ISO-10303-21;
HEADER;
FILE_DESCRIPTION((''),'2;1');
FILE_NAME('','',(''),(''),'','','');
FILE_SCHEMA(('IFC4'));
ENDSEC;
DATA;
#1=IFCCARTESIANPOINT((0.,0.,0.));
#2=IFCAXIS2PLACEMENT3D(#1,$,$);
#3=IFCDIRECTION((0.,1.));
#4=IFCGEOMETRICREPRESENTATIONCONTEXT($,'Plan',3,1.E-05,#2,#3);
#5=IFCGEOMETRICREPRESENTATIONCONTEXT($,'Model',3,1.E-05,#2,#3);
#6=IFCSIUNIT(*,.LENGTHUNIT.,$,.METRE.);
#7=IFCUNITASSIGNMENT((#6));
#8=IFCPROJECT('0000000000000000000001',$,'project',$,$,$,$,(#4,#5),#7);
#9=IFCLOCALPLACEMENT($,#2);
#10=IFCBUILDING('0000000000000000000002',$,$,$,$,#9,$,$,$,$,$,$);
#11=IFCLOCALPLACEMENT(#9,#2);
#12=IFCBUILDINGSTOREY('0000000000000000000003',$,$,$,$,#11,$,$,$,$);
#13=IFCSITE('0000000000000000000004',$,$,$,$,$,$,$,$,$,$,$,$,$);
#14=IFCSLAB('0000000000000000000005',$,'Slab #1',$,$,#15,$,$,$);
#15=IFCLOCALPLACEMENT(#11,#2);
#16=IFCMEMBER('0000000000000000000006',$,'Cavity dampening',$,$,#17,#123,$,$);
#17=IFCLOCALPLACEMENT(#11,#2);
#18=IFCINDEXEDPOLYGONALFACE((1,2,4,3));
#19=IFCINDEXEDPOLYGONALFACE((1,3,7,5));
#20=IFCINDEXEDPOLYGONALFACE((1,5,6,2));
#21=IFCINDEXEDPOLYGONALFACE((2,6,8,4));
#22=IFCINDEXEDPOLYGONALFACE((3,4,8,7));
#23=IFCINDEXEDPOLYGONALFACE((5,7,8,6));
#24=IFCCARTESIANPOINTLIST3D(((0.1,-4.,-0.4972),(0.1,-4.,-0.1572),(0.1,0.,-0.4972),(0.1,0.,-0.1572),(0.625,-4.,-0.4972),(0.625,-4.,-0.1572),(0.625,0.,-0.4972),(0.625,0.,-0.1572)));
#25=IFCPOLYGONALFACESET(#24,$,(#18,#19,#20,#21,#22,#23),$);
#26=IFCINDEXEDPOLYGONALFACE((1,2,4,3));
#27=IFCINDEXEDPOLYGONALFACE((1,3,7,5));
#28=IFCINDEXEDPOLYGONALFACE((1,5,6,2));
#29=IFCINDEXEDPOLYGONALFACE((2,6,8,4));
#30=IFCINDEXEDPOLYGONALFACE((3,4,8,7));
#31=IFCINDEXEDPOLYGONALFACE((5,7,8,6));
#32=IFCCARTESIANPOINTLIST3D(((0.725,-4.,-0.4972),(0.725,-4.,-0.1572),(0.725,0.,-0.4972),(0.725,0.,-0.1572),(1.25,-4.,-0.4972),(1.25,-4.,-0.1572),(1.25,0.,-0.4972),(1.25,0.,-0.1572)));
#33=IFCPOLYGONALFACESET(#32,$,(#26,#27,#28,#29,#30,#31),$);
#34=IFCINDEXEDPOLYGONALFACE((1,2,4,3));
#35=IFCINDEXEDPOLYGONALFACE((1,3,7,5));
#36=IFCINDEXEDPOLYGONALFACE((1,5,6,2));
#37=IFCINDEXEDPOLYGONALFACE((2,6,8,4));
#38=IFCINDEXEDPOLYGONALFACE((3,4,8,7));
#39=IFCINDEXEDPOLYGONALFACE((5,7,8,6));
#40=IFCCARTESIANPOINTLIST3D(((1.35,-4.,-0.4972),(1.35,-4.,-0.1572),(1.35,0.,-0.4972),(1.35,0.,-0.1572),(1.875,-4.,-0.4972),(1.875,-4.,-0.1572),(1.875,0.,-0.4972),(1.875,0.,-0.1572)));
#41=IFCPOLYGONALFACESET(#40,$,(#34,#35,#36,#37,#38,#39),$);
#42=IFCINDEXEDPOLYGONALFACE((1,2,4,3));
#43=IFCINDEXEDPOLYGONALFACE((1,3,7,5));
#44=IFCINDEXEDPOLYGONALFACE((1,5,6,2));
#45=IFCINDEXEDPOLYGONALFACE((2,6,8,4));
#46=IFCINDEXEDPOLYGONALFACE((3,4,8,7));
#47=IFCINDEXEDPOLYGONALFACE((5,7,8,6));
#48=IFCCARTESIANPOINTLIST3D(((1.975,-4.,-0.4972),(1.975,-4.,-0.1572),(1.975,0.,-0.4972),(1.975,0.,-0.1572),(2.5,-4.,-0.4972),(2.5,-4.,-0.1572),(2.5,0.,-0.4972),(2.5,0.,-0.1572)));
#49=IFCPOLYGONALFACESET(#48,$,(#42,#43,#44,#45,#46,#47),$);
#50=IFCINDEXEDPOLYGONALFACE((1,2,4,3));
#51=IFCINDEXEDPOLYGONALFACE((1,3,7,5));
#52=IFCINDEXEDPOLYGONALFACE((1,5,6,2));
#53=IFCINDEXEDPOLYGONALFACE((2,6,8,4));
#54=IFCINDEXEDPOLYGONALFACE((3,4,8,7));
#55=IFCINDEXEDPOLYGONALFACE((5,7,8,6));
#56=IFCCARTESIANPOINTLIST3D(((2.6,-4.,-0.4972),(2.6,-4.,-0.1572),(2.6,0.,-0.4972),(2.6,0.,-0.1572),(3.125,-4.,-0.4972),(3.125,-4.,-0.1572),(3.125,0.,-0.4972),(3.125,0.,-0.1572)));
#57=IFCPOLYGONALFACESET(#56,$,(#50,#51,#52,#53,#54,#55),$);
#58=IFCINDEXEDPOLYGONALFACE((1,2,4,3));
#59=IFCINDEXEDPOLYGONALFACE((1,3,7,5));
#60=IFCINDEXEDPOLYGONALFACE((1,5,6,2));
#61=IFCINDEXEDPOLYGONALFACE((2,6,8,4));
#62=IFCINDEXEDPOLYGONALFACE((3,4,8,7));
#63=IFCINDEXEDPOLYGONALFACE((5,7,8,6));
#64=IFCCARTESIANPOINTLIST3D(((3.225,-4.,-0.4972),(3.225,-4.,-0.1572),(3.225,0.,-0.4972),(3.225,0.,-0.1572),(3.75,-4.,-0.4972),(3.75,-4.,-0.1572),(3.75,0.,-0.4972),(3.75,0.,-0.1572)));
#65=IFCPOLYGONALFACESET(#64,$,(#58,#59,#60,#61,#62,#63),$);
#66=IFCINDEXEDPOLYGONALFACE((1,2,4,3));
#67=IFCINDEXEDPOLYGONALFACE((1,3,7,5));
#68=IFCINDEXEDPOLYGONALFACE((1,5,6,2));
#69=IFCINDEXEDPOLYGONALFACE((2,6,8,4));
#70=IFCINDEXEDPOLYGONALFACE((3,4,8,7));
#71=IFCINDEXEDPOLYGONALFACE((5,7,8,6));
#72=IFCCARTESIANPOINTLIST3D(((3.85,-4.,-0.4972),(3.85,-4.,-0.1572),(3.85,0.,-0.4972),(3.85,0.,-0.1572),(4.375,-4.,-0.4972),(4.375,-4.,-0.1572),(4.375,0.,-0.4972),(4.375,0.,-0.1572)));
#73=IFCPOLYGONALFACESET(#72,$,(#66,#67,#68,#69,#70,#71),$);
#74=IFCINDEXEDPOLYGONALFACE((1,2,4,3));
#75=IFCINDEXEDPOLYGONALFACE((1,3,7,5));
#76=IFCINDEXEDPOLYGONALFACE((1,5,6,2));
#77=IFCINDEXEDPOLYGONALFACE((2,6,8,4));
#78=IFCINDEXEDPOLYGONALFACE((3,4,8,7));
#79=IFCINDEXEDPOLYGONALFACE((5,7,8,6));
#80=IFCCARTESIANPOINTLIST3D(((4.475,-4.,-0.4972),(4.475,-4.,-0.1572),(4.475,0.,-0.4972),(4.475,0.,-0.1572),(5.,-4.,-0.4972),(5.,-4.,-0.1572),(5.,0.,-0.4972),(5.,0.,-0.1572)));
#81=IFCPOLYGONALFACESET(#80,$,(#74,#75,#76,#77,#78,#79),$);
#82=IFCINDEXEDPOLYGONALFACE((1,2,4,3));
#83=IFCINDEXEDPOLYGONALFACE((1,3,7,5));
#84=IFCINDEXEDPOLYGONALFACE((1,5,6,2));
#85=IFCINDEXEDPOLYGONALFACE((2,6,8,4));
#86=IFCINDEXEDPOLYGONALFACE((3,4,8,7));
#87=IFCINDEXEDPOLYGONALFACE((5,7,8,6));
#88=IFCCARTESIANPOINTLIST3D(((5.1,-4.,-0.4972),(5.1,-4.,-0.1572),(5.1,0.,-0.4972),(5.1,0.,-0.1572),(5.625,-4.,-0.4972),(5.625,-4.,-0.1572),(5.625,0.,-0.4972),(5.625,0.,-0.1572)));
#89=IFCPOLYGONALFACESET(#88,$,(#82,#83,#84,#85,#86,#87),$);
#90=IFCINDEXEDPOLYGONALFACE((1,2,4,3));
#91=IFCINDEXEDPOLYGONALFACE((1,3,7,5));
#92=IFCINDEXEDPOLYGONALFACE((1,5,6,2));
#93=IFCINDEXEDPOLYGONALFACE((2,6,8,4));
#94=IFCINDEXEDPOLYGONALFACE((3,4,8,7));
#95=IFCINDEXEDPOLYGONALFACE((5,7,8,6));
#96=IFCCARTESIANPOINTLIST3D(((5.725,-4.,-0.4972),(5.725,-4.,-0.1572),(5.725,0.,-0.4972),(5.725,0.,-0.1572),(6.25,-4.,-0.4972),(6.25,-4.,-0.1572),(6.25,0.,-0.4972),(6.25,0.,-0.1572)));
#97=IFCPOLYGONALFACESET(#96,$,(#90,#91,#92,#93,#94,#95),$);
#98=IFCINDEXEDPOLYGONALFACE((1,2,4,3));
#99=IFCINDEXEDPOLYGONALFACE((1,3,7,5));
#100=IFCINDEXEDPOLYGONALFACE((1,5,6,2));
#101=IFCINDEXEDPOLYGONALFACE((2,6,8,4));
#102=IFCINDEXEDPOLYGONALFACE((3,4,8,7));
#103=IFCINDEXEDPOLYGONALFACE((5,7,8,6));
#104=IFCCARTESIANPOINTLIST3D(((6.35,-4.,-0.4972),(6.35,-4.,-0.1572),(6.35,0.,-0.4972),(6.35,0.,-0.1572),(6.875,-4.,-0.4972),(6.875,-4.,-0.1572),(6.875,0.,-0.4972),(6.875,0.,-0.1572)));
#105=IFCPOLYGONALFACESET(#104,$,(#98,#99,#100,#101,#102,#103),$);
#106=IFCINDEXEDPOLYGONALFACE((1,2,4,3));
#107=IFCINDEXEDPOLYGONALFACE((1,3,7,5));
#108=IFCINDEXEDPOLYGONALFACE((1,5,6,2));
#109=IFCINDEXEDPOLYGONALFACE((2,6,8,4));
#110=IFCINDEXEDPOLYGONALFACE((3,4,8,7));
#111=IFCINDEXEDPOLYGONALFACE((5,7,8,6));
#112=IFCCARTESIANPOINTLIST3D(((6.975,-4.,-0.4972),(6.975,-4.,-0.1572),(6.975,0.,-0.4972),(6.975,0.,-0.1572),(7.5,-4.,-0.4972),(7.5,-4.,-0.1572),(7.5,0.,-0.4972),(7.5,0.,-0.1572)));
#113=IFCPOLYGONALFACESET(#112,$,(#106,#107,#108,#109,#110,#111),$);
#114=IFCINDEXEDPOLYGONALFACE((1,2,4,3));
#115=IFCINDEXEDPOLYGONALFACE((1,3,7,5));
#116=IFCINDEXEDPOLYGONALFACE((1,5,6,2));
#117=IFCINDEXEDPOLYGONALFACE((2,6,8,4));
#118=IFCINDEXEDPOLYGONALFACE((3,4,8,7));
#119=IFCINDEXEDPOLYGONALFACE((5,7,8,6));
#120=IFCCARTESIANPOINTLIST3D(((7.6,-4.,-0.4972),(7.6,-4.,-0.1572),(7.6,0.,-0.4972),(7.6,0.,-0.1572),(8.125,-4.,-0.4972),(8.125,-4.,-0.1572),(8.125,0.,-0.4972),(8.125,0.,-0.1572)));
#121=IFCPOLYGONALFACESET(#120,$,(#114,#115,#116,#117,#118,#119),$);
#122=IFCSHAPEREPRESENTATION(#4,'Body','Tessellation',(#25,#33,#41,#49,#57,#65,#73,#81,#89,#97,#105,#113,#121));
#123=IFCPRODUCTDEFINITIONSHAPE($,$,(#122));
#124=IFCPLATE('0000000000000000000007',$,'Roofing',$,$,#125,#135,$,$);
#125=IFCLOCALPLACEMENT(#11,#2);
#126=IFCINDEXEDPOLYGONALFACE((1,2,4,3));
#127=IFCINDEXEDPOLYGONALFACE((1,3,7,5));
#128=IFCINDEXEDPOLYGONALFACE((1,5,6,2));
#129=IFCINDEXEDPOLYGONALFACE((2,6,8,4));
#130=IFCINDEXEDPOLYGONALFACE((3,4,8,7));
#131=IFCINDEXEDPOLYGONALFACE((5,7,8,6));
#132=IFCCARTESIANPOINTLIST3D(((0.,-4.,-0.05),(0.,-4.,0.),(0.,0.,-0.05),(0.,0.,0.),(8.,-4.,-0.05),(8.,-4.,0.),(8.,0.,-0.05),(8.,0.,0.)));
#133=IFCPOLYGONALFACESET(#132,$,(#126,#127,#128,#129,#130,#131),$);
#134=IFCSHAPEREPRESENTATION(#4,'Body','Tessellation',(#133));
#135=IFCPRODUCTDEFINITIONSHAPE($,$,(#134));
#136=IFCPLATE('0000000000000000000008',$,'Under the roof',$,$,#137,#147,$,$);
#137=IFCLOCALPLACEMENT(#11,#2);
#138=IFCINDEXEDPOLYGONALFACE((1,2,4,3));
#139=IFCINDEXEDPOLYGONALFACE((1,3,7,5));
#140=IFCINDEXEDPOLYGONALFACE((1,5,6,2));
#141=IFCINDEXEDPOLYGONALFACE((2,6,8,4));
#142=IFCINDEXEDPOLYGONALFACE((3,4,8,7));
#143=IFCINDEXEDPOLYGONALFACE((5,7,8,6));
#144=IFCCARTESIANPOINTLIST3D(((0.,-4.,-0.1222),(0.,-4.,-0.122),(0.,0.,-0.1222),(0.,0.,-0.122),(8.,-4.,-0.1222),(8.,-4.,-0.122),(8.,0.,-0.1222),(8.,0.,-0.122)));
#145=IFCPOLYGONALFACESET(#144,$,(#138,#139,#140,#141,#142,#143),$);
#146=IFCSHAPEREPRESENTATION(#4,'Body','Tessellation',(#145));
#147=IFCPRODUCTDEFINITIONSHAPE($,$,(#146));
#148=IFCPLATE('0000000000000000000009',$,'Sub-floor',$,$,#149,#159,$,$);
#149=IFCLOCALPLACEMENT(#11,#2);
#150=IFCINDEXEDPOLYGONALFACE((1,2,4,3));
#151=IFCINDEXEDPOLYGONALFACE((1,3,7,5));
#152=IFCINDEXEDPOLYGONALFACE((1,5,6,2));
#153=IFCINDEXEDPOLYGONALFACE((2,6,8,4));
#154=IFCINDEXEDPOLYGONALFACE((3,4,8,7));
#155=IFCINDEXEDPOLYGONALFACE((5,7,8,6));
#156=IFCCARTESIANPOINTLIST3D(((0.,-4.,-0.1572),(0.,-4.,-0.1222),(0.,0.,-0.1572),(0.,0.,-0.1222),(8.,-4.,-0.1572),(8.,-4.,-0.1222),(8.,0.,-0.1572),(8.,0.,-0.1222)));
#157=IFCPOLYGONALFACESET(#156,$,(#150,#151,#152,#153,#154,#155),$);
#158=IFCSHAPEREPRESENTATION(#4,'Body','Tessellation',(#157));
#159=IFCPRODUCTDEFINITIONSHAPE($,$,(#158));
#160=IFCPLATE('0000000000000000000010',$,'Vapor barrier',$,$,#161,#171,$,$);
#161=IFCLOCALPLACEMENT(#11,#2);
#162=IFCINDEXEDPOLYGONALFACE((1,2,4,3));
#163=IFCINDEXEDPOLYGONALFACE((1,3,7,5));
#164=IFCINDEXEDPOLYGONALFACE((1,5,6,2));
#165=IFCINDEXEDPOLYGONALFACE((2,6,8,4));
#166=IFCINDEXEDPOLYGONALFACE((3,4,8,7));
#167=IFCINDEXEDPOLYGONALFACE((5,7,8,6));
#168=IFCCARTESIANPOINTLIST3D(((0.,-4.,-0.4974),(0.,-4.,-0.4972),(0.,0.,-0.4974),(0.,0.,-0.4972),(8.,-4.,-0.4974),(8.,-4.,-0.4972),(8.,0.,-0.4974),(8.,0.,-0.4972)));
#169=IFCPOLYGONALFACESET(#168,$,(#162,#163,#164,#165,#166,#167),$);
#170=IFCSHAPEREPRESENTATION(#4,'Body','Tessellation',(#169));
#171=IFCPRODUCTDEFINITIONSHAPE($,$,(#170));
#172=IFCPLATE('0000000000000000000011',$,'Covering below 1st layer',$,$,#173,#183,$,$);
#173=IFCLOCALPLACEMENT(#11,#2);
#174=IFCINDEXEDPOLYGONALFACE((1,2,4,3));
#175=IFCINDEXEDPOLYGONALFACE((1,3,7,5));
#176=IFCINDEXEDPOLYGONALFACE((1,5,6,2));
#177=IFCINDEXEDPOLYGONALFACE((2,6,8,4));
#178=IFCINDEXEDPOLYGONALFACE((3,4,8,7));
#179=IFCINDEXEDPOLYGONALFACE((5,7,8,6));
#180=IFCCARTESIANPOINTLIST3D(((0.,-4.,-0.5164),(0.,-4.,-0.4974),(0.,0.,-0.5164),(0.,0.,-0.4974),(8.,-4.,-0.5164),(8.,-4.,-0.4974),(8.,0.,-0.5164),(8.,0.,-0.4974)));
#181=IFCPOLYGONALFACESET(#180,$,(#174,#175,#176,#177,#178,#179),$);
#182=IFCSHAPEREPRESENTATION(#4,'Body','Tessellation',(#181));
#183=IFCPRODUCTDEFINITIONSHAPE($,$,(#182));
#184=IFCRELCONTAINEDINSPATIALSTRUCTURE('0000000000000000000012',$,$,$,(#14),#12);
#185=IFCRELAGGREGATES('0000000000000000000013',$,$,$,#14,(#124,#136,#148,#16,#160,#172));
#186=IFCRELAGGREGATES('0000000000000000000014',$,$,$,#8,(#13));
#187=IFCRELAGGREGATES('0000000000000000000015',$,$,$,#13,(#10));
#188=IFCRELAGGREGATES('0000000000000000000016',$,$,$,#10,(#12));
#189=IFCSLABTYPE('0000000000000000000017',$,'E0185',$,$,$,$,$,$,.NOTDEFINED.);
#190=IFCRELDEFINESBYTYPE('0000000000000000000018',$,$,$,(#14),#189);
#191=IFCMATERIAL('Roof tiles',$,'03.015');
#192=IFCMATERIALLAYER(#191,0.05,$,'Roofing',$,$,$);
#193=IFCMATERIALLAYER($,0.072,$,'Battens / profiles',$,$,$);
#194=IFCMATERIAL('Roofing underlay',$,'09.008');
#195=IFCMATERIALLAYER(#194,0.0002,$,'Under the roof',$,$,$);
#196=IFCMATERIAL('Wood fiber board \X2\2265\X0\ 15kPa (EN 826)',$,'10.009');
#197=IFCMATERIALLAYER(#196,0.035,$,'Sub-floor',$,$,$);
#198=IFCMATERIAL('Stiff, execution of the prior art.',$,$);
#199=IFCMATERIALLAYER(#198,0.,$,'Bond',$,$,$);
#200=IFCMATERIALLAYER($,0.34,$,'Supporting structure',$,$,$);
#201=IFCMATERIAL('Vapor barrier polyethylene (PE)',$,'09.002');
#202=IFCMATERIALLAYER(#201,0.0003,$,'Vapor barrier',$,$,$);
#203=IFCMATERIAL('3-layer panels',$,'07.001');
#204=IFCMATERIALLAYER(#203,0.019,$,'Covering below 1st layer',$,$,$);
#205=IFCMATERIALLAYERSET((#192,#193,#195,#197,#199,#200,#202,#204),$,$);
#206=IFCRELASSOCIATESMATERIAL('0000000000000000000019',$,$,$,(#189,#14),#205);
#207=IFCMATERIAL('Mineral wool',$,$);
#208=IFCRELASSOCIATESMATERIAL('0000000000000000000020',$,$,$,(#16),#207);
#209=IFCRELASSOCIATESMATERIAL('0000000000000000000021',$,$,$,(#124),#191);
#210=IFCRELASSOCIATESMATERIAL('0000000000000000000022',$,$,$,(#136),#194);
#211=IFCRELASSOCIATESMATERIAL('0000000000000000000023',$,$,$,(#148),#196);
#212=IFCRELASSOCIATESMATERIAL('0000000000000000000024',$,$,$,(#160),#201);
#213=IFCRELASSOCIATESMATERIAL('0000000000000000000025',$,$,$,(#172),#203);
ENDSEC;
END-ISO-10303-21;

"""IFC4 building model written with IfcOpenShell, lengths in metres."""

from ifc_helpers import new_model, si_unit, direction, frame, frame_2d, origin, origin_with_axes, place, context, project, spatial, rectangle, extrude, material, layer, layer_set, type_object, element, aggregate, save


model = new_model("IFC4")

# Units and contexts
plan_context = context("Plan", 3, precision=1e-05, world=origin(), true_north=direction((0.0, 1.0)))
model_context = context("Model", 3, precision=1e-05, world=origin(), true_north=direction((0.0, 1.0)))
ifc_project = project(units=[si_unit("LENGTHUNIT", "METRE")], contexts=[plan_context, model_context])

# Site, building, storey
site = spatial("IfcSite", under=ifc_project)
building_placement = place(None, origin())
building = spatial("IfcBuilding", under=site, at=building_placement)
storey_placement = place(building_placement, origin())
storey = spatial("IfcBuildingStorey", under=building, at=storey_placement)

# Slab, member, plates
ifc_material_1 = material(Name="Roof tiles", Category="03.015")
ifc_layer_1 = layer(ifc_material_1, 0.05, Name="Roofing")
ifc_layer_2 = layer(None, 0.072, Name="Battens / profiles")
ifc_material_2 = material(Name="Roofing underlay", Category="09.008")
ifc_layer_3 = layer(ifc_material_2, 0.0002, Name="Under the roof")
ifc_material_3 = material(Name="Wood fiber board ≥ 15kPa (EN 826)", Category="10.009")
ifc_layer_4 = layer(ifc_material_3, 0.035, Name="Sub-floor")
ifc_material_4 = material(Name="Stiff, execution of the prior art.")
ifc_layer_5 = layer(ifc_material_4, 0.0, Name="Bond")
ifc_layer_6 = layer(None, 0.34, Name="Supporting structure")
ifc_material_5 = material(Name="Vapor barrier polyethylene (PE)", Category="09.002")
ifc_layer_7 = layer(ifc_material_5, 0.0003, Name="Vapor barrier")
ifc_material_6 = material(Name="3-layer panels", Category="07.001")
ifc_layer_8 = layer(ifc_material_6, 0.019, Name="Covering below 1st layer")
ifc_layer_set = layer_set([ifc_layer_1, ifc_layer_2, ifc_layer_3, ifc_layer_4, ifc_layer_5, ifc_layer_6, ifc_layer_7, ifc_layer_8])
slab_type = type_object("IfcSlabType", Name="E0185", PredefinedType="NOTDEFINED", material=ifc_layer_set)
slab_placement = place(None, frame((0.0, 0.0, 0.0), z_axis=(0.0, 0.0, -1.0), x_axis=(1.0, 0.0, 0.0)))
slab = element("IfcSlab", 1, at=slab_placement, inside=storey, type_object=slab_type, material=ifc_layer_set, Name="Slab #1")
ifc_material_7 = material(Name="Mineral wool")
member_1_placement = place(slab_placement, origin())
member_1 = element("IfcMember", 2, at=member_1_placement, material=ifc_material_7, Name="Cavity dampening", context=plan_context, shape_type="SweptSolid", body=[
    extrude(rectangle(XDim=0.525, YDim=0.34, at=frame_2d((0.2625, 0.17), x_axis=(1.0, 0.0))), frame((0.1, 4.0, 0.1572), z_axis=(0.0, -1.0, 0.0), x_axis=(1.0, 0.0, 0.0)), (0.0, 0.0, 1.0), 4.0),
    extrude(rectangle(XDim=0.525, YDim=0.34, at=frame_2d((0.2625, 0.17), x_axis=(1.0, 0.0))), frame((0.725, 4.0, 0.1572), z_axis=(0.0, -1.0, 0.0), x_axis=(1.0, 0.0, 0.0)), (0.0, 0.0, 1.0), 4.0),
    extrude(rectangle(XDim=0.525, YDim=0.34, at=frame_2d((0.2625, 0.17), x_axis=(1.0, 0.0))), frame((1.35, 4.0, 0.1572), z_axis=(0.0, -1.0, 0.0), x_axis=(1.0, 0.0, 0.0)), (0.0, 0.0, 1.0), 4.0),
    extrude(rectangle(XDim=0.525, YDim=0.34, at=frame_2d((0.2625, 0.17), x_axis=(1.0, 0.0))), frame((1.975, 4.0, 0.1572), z_axis=(0.0, -1.0, 0.0), x_axis=(1.0, 0.0, 0.0)), (0.0, 0.0, 1.0), 4.0),
    extrude(rectangle(XDim=0.525, YDim=0.34, at=frame_2d((0.2625, 0.17), x_axis=(1.0, 0.0))), frame((2.6, 4.0, 0.1572), z_axis=(0.0, -1.0, 0.0), x_axis=(1.0, 0.0, 0.0)), (0.0, 0.0, 1.0), 4.0),
    extrude(rectangle(XDim=0.525, YDim=0.34, at=frame_2d((0.2625, 0.17), x_axis=(1.0, 0.0))), frame((3.225, 4.0, 0.1572), z_axis=(0.0, -1.0, 0.0), x_axis=(1.0, 0.0, 0.0)), (0.0, 0.0, 1.0), 4.0),
    extrude(rectangle(XDim=0.525, YDim=0.34, at=frame_2d((0.2625, 0.17), x_axis=(1.0, 0.0))), frame((3.85, 4.0, 0.1572), z_axis=(0.0, -1.0, 0.0), x_axis=(1.0, 0.0, 0.0)), (0.0, 0.0, 1.0), 4.0),
    extrude(rectangle(XDim=0.525, YDim=0.34, at=frame_2d((0.2625, 0.17), x_axis=(1.0, 0.0))), frame((4.475, 4.0, 0.1572), z_axis=(0.0, -1.0, 0.0), x_axis=(1.0, 0.0, 0.0)), (0.0, 0.0, 1.0), 4.0),
    extrude(rectangle(XDim=0.525, YDim=0.34, at=frame_2d((0.2625, 0.17), x_axis=(1.0, 0.0))), frame((5.1, 4.0, 0.1572), z_axis=(0.0, -1.0, 0.0), x_axis=(1.0, 0.0, 0.0)), (0.0, 0.0, 1.0), 4.0),
    extrude(rectangle(XDim=0.525, YDim=0.34, at=frame_2d((0.2625, 0.17), x_axis=(1.0, 0.0))), frame((5.725, 4.0, 0.1572), z_axis=(0.0, -1.0, 0.0), x_axis=(1.0, 0.0, 0.0)), (0.0, 0.0, 1.0), 4.0),
    extrude(rectangle(XDim=0.525, YDim=0.34, at=frame_2d((0.2625, 0.17), x_axis=(1.0, 0.0))), frame((6.35, 4.0, 0.1572), z_axis=(0.0, -1.0, 0.0), x_axis=(1.0, 0.0, 0.0)), (0.0, 0.0, 1.0), 4.0),
    extrude(rectangle(XDim=0.525, YDim=0.34, at=frame_2d((0.2625, 0.17), x_axis=(1.0, 0.0))), frame((6.975, 4.0, 0.1572), z_axis=(0.0, -1.0, 0.0), x_axis=(1.0, 0.0, 0.0)), (0.0, 0.0, 1.0), 4.0),
    extrude(rectangle(XDim=0.525, YDim=0.34, at=frame_2d((0.2625, 0.17), x_axis=(1.0, 0.0))), frame((7.6, 4.0, 0.1572), z_axis=(0.0, -1.0, 0.0), x_axis=(1.0, 0.0, 0.0)), (0.0, 0.0, 1.0), 4.0),
])
plate_1_placement = place(slab_placement, origin())
plate_1 = element("IfcPlate", 3, at=plate_1_placement, material=ifc_material_1, Name="Roofing", context=plan_context, shape_type="SweptSolid", body=[
    extrude(rectangle(XDim=8.0, YDim=4.0, at=frame_2d((4.0, 2.0), x_axis=(1.0, 0.0))), origin_with_axes(), (0.0, 0.0, 1.0), 0.05),
])
plate_2_placement = place(slab_placement, origin())
plate_2 = element("IfcPlate", 4, at=plate_2_placement, material=ifc_material_2, Name="Under the roof", context=plan_context, shape_type="SweptSolid", body=[
    extrude(rectangle(XDim=8.0, YDim=4.0, at=frame_2d((4.0, 2.0), x_axis=(1.0, 0.0))), frame((0.0, 0.0, 0.122), z_axis=(0.0, 0.0, 1.0), x_axis=(1.0, 0.0, 0.0)), (0.0, 0.0, 1.0), 0.0002),
])
plate_3_placement = place(slab_placement, origin())
plate_3 = element("IfcPlate", 5, at=plate_3_placement, material=ifc_material_3, Name="Sub-floor", context=plan_context, shape_type="SweptSolid", body=[
    extrude(rectangle(XDim=8.0, YDim=4.0, at=frame_2d((4.0, 2.0), x_axis=(1.0, 0.0))), frame((0.0, 0.0, 0.1222), z_axis=(0.0, 0.0, 1.0), x_axis=(1.0, 0.0, 0.0)), (0.0, 0.0, 1.0), 0.035),
])
plate_4_placement = place(slab_placement, origin())
plate_4 = element("IfcPlate", 6, at=plate_4_placement, material=ifc_material_5, Name="Vapor barrier", context=plan_context, shape_type="SweptSolid", body=[
    extrude(rectangle(XDim=8.0, YDim=4.0, at=frame_2d((4.0, 2.0), x_axis=(1.0, 0.0))), frame((0.0, 0.0, 0.4972), z_axis=(0.0, 0.0, 1.0), x_axis=(1.0, 0.0, 0.0)), (0.0, 0.0, 1.0), 0.0003),
])
plate_5_placement = place(slab_placement, origin())
plate_5 = element("IfcPlate", 7, at=plate_5_placement, material=ifc_material_6, Name="Covering below 1st layer", context=plan_context, shape_type="SweptSolid", body=[
    extrude(rectangle(XDim=8.0, YDim=4.0, at=frame_2d((4.0, 2.0), x_axis=(1.0, 0.0))), frame((0.0, 0.0, 0.4974), z_axis=(0.0, 0.0, 1.0), x_axis=(1.0, 0.0, 0.0)), (0.0, 0.0, 1.0), 0.019),
])
aggregate(slab, [plate_1, plate_2, plate_3, member_1, plate_4, plate_5])

save(model, "model.ifc")
